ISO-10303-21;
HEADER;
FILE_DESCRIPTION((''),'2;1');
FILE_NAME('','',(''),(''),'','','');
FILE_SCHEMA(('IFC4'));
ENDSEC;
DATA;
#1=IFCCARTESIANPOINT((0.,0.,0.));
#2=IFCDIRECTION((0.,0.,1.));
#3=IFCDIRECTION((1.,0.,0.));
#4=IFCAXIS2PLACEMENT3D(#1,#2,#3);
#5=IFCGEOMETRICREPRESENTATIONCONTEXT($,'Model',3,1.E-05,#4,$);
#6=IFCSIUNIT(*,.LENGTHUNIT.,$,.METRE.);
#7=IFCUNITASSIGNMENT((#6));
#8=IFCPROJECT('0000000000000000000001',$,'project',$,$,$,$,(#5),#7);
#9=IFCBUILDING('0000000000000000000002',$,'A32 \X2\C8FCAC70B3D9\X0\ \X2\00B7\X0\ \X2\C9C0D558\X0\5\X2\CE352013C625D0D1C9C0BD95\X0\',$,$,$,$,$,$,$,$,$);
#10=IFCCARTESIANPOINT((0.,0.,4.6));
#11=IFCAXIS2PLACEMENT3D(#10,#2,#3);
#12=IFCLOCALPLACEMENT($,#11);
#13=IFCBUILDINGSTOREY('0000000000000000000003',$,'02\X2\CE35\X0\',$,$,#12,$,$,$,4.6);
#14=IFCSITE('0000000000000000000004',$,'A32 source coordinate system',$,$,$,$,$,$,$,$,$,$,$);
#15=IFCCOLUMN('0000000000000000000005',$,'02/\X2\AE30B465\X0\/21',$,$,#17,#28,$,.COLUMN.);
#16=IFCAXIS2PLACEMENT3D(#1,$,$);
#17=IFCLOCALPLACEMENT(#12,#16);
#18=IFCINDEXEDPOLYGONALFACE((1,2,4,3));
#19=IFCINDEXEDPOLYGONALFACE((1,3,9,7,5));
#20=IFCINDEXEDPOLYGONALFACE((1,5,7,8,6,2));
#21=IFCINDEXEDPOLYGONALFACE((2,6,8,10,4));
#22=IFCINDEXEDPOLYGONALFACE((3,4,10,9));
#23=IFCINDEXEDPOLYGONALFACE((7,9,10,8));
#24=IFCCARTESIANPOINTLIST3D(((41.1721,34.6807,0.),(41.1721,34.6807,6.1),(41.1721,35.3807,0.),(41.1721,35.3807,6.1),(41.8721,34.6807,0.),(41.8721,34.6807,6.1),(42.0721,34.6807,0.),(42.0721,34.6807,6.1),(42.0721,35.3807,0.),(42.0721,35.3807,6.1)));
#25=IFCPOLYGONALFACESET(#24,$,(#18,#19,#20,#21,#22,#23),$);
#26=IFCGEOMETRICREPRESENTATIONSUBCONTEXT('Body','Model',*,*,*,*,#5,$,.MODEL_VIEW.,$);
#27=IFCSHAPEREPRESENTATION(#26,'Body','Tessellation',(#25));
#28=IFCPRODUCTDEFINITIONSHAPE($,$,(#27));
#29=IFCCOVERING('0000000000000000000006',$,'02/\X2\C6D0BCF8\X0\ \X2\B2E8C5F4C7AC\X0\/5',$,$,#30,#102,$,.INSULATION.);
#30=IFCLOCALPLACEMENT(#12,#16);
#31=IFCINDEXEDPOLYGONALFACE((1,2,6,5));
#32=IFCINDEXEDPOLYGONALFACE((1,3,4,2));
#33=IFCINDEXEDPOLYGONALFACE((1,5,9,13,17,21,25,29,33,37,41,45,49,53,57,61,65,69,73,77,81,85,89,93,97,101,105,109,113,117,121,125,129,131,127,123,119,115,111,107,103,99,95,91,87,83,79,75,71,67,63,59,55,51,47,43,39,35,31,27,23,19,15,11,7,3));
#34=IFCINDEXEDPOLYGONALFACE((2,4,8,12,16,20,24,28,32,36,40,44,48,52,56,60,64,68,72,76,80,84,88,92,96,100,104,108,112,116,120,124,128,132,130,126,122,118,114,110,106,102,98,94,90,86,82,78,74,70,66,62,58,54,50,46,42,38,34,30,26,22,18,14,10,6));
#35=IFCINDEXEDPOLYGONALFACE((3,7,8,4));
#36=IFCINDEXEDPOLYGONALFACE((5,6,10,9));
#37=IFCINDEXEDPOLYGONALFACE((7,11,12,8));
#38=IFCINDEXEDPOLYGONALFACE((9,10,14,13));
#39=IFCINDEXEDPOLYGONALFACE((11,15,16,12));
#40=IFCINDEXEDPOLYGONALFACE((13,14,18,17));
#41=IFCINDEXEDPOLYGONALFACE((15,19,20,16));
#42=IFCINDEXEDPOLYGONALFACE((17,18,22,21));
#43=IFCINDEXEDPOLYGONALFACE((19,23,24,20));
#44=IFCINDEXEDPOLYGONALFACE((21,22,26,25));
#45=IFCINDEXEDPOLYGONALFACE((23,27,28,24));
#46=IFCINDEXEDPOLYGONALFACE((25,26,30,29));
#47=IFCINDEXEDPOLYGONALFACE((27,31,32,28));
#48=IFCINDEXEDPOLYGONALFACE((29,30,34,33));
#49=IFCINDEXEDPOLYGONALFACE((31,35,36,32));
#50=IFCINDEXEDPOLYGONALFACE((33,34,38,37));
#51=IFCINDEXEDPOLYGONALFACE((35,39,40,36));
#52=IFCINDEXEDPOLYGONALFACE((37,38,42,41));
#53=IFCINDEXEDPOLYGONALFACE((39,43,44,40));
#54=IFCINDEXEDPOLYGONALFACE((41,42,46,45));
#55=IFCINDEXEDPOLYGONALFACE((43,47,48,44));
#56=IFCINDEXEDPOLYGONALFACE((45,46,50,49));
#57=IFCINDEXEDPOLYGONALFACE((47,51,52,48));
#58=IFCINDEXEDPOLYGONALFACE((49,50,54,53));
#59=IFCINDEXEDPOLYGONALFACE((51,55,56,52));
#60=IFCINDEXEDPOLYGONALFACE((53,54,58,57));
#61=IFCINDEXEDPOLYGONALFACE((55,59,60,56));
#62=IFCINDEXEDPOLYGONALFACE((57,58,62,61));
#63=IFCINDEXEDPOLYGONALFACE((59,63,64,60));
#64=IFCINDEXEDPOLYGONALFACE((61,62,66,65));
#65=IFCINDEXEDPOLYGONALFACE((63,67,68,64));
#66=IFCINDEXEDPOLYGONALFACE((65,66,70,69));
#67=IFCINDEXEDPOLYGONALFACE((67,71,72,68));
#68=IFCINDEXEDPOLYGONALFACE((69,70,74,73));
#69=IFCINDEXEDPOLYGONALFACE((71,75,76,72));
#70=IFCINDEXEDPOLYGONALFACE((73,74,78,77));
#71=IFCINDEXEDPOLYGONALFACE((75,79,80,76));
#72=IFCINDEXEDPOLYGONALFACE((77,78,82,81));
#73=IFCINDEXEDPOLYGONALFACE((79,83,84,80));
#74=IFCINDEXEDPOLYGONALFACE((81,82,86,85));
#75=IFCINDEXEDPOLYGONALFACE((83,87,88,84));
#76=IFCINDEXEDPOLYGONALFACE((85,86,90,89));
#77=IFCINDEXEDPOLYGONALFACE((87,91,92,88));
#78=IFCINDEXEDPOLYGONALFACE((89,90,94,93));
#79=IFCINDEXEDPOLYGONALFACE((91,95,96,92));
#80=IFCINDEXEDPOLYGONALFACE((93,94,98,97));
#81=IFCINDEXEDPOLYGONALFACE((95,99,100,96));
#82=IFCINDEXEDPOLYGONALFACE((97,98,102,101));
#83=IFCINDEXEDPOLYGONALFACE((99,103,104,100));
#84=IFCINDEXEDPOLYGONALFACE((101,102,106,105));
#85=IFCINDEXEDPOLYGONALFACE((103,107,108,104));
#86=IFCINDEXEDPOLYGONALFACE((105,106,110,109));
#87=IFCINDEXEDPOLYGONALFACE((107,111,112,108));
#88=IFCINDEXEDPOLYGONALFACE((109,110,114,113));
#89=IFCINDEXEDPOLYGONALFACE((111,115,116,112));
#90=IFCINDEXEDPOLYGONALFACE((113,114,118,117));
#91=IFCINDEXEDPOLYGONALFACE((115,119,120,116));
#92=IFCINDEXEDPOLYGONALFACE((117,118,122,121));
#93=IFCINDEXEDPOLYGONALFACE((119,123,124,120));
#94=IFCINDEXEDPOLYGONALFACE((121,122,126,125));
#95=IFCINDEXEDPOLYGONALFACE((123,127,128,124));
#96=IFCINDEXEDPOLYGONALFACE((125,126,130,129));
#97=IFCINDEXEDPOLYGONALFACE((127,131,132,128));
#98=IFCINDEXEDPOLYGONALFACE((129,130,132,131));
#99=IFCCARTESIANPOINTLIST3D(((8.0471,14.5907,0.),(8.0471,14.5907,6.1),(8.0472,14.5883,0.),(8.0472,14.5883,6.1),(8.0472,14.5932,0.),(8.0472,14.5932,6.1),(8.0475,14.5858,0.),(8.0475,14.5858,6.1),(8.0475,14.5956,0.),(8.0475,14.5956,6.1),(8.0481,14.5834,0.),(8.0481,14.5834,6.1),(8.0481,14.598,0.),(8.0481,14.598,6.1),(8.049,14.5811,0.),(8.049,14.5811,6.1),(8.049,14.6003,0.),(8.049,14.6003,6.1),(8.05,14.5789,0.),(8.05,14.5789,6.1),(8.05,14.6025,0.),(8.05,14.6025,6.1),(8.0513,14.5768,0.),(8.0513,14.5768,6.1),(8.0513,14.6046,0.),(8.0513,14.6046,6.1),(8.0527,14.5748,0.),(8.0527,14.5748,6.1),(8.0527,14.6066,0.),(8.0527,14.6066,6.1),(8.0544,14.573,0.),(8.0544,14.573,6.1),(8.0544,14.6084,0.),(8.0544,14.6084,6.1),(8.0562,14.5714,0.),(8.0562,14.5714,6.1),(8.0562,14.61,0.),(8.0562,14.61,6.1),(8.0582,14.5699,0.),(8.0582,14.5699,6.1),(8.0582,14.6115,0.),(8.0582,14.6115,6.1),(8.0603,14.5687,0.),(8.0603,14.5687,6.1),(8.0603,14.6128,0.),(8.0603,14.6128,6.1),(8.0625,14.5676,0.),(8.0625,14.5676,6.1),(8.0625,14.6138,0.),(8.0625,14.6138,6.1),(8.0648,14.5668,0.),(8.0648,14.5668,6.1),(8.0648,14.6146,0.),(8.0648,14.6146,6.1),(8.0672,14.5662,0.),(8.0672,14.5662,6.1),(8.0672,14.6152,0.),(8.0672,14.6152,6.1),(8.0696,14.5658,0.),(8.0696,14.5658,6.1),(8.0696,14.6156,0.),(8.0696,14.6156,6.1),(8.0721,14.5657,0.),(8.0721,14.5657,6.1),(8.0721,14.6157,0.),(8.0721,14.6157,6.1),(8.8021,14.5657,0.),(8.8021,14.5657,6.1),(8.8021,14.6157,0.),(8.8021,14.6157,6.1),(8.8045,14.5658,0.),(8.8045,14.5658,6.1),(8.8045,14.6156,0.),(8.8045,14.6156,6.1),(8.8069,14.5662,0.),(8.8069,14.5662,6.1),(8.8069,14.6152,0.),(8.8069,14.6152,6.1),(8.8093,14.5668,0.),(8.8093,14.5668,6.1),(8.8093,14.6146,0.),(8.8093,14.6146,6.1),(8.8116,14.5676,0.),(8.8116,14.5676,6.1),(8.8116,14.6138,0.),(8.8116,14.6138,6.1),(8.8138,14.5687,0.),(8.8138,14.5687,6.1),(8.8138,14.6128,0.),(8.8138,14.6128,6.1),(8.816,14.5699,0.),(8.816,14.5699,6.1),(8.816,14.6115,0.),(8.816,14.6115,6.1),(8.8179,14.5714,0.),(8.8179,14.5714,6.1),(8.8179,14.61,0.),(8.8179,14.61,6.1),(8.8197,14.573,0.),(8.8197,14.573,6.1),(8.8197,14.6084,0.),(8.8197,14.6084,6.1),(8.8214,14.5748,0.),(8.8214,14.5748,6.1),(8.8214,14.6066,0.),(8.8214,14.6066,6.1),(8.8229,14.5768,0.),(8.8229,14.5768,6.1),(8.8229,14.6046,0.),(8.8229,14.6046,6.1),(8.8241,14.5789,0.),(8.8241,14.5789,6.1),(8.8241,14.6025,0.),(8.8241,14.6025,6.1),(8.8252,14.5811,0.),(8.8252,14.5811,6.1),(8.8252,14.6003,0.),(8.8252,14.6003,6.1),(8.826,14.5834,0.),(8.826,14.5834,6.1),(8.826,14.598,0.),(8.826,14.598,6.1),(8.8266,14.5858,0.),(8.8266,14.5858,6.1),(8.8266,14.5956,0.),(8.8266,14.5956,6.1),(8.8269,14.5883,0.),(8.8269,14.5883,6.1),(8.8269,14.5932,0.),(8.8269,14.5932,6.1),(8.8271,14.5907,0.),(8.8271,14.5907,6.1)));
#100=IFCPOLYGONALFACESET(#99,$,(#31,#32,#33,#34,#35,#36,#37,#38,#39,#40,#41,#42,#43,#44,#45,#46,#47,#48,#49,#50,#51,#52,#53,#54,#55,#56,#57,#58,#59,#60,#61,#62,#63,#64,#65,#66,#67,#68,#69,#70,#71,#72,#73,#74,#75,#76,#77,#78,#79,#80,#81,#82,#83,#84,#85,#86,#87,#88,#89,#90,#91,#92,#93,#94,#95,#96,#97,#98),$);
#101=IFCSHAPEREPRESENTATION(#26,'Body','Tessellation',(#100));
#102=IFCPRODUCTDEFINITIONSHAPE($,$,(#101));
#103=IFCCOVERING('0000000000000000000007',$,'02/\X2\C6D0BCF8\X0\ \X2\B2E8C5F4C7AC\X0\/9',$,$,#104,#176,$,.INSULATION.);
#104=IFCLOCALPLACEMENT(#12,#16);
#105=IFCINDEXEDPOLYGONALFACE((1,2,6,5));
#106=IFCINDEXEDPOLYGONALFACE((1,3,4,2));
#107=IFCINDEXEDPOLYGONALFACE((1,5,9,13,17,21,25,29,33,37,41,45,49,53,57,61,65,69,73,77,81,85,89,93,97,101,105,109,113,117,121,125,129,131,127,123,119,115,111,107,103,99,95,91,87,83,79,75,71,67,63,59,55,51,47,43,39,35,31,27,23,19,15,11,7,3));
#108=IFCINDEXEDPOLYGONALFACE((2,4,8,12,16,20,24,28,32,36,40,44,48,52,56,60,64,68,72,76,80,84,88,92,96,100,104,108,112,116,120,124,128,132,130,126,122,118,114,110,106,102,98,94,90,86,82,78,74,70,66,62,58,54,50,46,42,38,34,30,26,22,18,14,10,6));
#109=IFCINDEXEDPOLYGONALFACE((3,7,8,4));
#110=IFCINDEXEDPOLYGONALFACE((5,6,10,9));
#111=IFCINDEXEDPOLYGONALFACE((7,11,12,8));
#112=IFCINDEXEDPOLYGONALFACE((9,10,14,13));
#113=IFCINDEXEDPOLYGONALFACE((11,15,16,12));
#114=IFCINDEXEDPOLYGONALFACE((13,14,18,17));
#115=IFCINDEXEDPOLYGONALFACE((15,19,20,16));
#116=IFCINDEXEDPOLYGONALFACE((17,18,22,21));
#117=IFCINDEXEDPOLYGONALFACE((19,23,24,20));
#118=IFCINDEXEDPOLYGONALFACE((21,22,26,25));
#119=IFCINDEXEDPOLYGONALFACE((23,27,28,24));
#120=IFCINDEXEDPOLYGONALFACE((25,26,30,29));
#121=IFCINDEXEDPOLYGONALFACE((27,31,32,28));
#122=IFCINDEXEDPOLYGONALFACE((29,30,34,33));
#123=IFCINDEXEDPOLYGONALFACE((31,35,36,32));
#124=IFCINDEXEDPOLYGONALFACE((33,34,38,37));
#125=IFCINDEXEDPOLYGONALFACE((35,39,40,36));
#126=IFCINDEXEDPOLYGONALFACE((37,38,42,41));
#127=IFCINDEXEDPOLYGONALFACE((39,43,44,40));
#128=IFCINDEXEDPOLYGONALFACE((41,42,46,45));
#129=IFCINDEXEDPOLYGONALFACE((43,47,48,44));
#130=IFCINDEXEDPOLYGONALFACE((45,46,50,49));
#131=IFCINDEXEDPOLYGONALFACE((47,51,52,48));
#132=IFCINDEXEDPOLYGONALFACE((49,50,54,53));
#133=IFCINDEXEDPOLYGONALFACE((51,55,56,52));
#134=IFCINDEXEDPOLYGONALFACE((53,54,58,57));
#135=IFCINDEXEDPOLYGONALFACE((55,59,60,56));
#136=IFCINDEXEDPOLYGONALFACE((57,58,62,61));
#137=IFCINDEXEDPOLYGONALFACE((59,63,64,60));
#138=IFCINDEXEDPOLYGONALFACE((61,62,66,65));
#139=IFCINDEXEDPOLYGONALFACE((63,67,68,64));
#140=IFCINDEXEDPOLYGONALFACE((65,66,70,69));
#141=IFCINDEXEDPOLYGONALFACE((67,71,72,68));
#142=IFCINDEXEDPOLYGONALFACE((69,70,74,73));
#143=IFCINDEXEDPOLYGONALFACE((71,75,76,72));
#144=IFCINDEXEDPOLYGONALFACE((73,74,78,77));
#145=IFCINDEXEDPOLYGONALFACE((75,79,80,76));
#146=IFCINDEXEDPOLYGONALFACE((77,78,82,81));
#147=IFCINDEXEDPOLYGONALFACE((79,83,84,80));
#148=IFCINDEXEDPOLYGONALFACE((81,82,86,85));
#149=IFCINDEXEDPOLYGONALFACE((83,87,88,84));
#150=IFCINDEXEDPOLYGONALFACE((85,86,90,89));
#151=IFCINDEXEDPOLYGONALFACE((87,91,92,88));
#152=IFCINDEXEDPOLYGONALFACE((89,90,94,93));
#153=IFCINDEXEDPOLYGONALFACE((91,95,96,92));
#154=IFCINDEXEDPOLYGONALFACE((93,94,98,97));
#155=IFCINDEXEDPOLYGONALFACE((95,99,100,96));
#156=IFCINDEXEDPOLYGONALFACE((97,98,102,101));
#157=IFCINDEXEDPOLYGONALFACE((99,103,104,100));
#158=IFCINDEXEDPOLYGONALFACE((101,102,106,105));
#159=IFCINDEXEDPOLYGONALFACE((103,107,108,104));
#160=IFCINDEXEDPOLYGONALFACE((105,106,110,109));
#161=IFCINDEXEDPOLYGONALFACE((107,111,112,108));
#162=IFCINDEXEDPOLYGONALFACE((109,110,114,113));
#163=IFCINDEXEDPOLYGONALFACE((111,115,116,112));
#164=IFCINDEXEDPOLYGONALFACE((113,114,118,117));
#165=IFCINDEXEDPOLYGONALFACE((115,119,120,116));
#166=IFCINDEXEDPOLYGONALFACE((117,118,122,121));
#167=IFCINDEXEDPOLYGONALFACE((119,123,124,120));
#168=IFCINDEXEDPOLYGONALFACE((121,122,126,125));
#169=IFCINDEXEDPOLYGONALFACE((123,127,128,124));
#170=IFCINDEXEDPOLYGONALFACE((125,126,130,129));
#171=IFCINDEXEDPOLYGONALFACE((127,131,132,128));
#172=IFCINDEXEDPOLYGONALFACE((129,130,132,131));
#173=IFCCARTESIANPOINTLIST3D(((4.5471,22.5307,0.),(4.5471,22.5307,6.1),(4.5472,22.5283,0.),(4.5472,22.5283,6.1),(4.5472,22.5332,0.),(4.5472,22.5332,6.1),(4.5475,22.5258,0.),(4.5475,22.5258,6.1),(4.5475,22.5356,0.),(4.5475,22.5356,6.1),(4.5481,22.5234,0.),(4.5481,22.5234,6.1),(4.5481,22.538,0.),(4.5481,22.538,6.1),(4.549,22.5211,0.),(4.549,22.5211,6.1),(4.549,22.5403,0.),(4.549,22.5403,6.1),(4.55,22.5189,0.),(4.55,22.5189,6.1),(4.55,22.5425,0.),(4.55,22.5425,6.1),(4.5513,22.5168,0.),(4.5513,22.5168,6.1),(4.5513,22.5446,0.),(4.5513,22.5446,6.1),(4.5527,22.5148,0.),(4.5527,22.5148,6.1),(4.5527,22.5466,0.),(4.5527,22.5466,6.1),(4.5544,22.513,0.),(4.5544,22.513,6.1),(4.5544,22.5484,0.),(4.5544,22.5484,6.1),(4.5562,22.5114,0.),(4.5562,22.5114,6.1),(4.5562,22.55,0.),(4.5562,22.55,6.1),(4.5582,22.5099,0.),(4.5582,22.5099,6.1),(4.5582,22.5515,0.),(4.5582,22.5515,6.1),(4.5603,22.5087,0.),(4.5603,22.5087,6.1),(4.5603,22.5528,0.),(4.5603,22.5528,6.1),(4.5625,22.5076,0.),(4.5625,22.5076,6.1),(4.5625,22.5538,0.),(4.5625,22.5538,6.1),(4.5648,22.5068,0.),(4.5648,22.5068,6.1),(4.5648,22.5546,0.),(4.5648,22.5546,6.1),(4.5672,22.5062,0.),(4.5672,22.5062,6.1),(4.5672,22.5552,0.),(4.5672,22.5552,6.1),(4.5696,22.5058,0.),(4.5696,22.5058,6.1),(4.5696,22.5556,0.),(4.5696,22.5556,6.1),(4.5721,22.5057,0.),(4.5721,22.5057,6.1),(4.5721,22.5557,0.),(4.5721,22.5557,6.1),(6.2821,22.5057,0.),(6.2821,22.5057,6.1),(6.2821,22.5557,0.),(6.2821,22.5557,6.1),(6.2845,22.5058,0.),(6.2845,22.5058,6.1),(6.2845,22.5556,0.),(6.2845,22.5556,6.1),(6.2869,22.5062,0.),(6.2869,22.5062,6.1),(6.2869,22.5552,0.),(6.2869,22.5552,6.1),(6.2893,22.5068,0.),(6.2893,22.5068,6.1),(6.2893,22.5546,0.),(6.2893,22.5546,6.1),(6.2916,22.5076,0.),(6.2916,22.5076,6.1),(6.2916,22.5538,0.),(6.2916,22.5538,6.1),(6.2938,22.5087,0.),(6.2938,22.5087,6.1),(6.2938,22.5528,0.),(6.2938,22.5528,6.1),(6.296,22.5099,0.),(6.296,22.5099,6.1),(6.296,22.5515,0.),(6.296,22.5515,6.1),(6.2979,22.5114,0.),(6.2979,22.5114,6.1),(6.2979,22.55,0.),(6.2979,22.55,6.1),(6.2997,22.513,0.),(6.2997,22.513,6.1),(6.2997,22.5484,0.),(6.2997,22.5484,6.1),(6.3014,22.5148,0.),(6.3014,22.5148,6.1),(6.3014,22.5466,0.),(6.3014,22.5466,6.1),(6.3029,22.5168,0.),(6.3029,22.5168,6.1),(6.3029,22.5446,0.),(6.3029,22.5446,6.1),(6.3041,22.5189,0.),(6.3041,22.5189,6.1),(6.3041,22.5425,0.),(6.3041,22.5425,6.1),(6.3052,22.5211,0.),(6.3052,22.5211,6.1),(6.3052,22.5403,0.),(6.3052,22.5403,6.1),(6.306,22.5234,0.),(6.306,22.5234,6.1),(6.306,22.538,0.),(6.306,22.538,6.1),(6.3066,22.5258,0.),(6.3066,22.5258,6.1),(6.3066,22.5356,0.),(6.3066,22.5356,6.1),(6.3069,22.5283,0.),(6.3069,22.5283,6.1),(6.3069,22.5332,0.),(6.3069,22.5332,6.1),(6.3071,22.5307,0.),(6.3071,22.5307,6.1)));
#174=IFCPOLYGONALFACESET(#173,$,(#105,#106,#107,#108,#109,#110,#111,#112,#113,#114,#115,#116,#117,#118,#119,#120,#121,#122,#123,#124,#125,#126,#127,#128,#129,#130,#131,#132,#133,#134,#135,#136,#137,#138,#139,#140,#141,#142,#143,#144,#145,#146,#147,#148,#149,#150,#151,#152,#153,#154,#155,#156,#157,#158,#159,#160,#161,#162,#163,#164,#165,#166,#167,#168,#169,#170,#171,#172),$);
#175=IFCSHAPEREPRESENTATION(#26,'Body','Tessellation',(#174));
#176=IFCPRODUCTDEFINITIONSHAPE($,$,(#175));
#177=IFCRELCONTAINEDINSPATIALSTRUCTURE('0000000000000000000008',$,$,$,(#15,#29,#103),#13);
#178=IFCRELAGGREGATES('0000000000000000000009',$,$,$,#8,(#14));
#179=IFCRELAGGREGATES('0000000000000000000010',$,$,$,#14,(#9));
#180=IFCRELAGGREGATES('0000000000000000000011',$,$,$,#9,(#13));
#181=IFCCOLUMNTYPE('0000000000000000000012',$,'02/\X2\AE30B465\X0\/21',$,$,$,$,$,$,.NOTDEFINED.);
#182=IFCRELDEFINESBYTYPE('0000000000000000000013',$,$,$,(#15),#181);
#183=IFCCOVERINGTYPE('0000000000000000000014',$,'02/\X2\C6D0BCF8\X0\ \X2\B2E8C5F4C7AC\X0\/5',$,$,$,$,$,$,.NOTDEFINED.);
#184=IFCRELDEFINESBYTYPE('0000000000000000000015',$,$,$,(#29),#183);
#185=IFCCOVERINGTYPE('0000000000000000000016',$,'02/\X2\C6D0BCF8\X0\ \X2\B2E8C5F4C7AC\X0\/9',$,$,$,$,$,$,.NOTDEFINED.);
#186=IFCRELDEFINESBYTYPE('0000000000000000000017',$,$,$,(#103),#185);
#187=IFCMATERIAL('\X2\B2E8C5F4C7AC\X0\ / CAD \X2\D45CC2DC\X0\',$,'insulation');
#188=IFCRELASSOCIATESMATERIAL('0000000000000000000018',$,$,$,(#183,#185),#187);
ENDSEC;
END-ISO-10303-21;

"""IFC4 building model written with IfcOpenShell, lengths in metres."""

from ifc_helpers import new_model, si_unit, frame, origin, origin_with_axes, place, context, subcontext, project, spatial, polyline, outline, extrude, source, transform, mapped, material, type_object, type_shapes, element, save


model = new_model("IFC4")

# Units and contexts
model_context = context("Model", 3, precision=1e-05, world=origin_with_axes())
body_context = subcontext(model_context, "Body", "Model", "MODEL_VIEW")
ifc_project = project(units=[si_unit("LENGTHUNIT", "METRE")], contexts=[model_context])

# Site, building, storey
site = spatial("IfcSite", under=ifc_project, Name="A32 source coordinate system")
building = spatial("IfcBuilding", under=site, Name="A32 주거동 · 지하5층–옥탑지붕")
storey_placement = place(None, frame((0.0, 0.0, 4.6), z_axis=(0.0, 0.0, 1.0), x_axis=(1.0, 0.0, 0.0)))
storey = spatial("IfcBuildingStorey", under=building, at=storey_placement, Name="02층", Elevation=4.6)

# Column
column_type = type_object("IfcColumnType", Name="02/기둥/21", PredefinedType="NOTDEFINED")
shared_shape_1 = source(origin(), body_context, "Body", "SweptSolid", [
    extrude(outline(polyline([(42.0721, 34.6807), (41.8721, 34.6807), (41.1721, 34.6807), (41.1721, 35.3807), (42.0721, 35.3807), (42.0721, 34.6807)])), origin(), (0.0, 0.0, 1.0), 6.1),
])
type_shapes(column_type, [shared_shape_1])
column_placement = place(storey_placement, origin_with_axes())
element("IfcColumn", 1, at=column_placement, inside=storey, type_object=column_type, Name="02/기둥/21", PredefinedType="COLUMN", context=body_context, shape_type="MappedRepresentation", body=[
    mapped(shared_shape_1, transform((0.0, 0.0, 0.0), scale=1.0)),
])

# Coverings
ifc_material = material(Name="단열재 / CAD 표시", Category="insulation")
covering_type_1 = type_object("IfcCoveringType", Name="02/원본 단열재/5", PredefinedType="NOTDEFINED", material=ifc_material)
shared_shape_2 = source(origin(), body_context, "Body", "SweptSolid", [
    extrude(outline(polyline([(8.8138, 14.6128), (8.816, 14.6115), (8.8179, 14.61), (8.8197, 14.6084), (8.8214, 14.6066), (8.8229, 14.6046), (8.8241, 14.6025), (8.8252, 14.6003), (8.826, 14.598), (8.8266, 14.5956), (8.8269, 14.5932), (8.8271, 14.5907), (8.8269, 14.5883), (8.8266, 14.5858), (8.826, 14.5834), (8.8252, 14.5811), (8.8241, 14.5789), (8.8229, 14.5768), (8.8214, 14.5748), (8.8197, 14.573), (8.8179, 14.5714), (8.816, 14.5699), (8.8138, 14.5687), (8.8116, 14.5676), (8.8093, 14.5668), (8.8069, 14.5662), (8.8045, 14.5658), (8.8021, 14.5657), (8.0721, 14.5657), (8.0696, 14.5658), (8.0672, 14.5662), (8.0648, 14.5668), (8.0625, 14.5676), (8.0603, 14.5687), (8.0582, 14.5699), (8.0562, 14.5714), (8.0544, 14.573), (8.0527, 14.5748), (8.0513, 14.5768), (8.05, 14.5789), (8.049, 14.5811), (8.0481, 14.5834), (8.0475, 14.5858), (8.0472, 14.5883), (8.0471, 14.5907), (8.0472, 14.5932), (8.0475, 14.5956), (8.0481, 14.598), (8.049, 14.6003), (8.05, 14.6025), (8.0513, 14.6046), (8.0527, 14.6066), (8.0544, 14.6084), (8.0562, 14.61), (8.0582, 14.6115), (8.0603, 14.6128), (8.0625, 14.6138), (8.0648, 14.6146), (8.0672, 14.6152), (8.0696, 14.6156), (8.0721, 14.6157), (8.8021, 14.6157), (8.8045, 14.6156), (8.8069, 14.6152), (8.8093, 14.6146), (8.8116, 14.6138), (8.8138, 14.6128)])), origin(), (0.0, 0.0, 1.0), 6.1),
])
type_shapes(covering_type_1, [shared_shape_2])
covering_1_placement = place(storey_placement, origin_with_axes())
element("IfcCovering", 2, at=covering_1_placement, inside=storey, type_object=covering_type_1, Name="02/원본 단열재/5", PredefinedType="INSULATION", context=body_context, shape_type="MappedRepresentation", body=[
    mapped(shared_shape_2, transform((0.0, 0.0, 0.0), scale=1.0)),
])
covering_type_2 = type_object("IfcCoveringType", Name="02/원본 단열재/9", PredefinedType="NOTDEFINED", material=ifc_material)
shared_shape_3 = source(origin(), body_context, "Body", "SweptSolid", [
    extrude(outline(polyline([(4.5603, 22.5087), (4.5582, 22.5099), (4.5562, 22.5114), (4.5544, 22.513), (4.5527, 22.5148), (4.5513, 22.5168), (4.55, 22.5189), (4.549, 22.5211), (4.5481, 22.5234), (4.5475, 22.5258), (4.5472, 22.5283), (4.5471, 22.5307), (4.5472, 22.5332), (4.5475, 22.5356), (4.5481, 22.538), (4.549, 22.5403), (4.55, 22.5425), (4.5513, 22.5446), (4.5527, 22.5466), (4.5544, 22.5484), (4.5562, 22.55), (4.5582, 22.5515), (4.5603, 22.5528), (4.5625, 22.5538), (4.5648, 22.5546), (4.5672, 22.5552), (4.5696, 22.5556), (4.5721, 22.5557), (6.2821, 22.5557), (6.2845, 22.5556), (6.2869, 22.5552), (6.2893, 22.5546), (6.2916, 22.5538), (6.2938, 22.5528), (6.296, 22.5515), (6.2979, 22.55), (6.2997, 22.5484), (6.3014, 22.5466), (6.3029, 22.5446), (6.3041, 22.5425), (6.3052, 22.5403), (6.306, 22.538), (6.3066, 22.5356), (6.3069, 22.5332), (6.3071, 22.5307), (6.3069, 22.5283), (6.3066, 22.5258), (6.306, 22.5234), (6.3052, 22.5211), (6.3041, 22.5189), (6.3029, 22.5168), (6.3014, 22.5148), (6.2997, 22.513), (6.2979, 22.5114), (6.296, 22.5099), (6.2938, 22.5087), (6.2916, 22.5076), (6.2893, 22.5068), (6.2869, 22.5062), (6.2845, 22.5058), (6.2821, 22.5057), (4.5721, 22.5057), (4.5696, 22.5058), (4.5672, 22.5062), (4.5648, 22.5068), (4.5625, 22.5076), (4.5603, 22.5087)])), origin(), (0.0, 0.0, 1.0), 6.1),
])
type_shapes(covering_type_2, [shared_shape_3])
covering_2_placement = place(storey_placement, origin_with_axes())
element("IfcCovering", 3, at=covering_2_placement, inside=storey, type_object=covering_type_2, Name="02/원본 단열재/9", PredefinedType="INSULATION", context=body_context, shape_type="MappedRepresentation", body=[
    mapped(shared_shape_3, transform((0.0, 0.0, 0.0), scale=1.0)),
])

save(model, "model.ifc")
